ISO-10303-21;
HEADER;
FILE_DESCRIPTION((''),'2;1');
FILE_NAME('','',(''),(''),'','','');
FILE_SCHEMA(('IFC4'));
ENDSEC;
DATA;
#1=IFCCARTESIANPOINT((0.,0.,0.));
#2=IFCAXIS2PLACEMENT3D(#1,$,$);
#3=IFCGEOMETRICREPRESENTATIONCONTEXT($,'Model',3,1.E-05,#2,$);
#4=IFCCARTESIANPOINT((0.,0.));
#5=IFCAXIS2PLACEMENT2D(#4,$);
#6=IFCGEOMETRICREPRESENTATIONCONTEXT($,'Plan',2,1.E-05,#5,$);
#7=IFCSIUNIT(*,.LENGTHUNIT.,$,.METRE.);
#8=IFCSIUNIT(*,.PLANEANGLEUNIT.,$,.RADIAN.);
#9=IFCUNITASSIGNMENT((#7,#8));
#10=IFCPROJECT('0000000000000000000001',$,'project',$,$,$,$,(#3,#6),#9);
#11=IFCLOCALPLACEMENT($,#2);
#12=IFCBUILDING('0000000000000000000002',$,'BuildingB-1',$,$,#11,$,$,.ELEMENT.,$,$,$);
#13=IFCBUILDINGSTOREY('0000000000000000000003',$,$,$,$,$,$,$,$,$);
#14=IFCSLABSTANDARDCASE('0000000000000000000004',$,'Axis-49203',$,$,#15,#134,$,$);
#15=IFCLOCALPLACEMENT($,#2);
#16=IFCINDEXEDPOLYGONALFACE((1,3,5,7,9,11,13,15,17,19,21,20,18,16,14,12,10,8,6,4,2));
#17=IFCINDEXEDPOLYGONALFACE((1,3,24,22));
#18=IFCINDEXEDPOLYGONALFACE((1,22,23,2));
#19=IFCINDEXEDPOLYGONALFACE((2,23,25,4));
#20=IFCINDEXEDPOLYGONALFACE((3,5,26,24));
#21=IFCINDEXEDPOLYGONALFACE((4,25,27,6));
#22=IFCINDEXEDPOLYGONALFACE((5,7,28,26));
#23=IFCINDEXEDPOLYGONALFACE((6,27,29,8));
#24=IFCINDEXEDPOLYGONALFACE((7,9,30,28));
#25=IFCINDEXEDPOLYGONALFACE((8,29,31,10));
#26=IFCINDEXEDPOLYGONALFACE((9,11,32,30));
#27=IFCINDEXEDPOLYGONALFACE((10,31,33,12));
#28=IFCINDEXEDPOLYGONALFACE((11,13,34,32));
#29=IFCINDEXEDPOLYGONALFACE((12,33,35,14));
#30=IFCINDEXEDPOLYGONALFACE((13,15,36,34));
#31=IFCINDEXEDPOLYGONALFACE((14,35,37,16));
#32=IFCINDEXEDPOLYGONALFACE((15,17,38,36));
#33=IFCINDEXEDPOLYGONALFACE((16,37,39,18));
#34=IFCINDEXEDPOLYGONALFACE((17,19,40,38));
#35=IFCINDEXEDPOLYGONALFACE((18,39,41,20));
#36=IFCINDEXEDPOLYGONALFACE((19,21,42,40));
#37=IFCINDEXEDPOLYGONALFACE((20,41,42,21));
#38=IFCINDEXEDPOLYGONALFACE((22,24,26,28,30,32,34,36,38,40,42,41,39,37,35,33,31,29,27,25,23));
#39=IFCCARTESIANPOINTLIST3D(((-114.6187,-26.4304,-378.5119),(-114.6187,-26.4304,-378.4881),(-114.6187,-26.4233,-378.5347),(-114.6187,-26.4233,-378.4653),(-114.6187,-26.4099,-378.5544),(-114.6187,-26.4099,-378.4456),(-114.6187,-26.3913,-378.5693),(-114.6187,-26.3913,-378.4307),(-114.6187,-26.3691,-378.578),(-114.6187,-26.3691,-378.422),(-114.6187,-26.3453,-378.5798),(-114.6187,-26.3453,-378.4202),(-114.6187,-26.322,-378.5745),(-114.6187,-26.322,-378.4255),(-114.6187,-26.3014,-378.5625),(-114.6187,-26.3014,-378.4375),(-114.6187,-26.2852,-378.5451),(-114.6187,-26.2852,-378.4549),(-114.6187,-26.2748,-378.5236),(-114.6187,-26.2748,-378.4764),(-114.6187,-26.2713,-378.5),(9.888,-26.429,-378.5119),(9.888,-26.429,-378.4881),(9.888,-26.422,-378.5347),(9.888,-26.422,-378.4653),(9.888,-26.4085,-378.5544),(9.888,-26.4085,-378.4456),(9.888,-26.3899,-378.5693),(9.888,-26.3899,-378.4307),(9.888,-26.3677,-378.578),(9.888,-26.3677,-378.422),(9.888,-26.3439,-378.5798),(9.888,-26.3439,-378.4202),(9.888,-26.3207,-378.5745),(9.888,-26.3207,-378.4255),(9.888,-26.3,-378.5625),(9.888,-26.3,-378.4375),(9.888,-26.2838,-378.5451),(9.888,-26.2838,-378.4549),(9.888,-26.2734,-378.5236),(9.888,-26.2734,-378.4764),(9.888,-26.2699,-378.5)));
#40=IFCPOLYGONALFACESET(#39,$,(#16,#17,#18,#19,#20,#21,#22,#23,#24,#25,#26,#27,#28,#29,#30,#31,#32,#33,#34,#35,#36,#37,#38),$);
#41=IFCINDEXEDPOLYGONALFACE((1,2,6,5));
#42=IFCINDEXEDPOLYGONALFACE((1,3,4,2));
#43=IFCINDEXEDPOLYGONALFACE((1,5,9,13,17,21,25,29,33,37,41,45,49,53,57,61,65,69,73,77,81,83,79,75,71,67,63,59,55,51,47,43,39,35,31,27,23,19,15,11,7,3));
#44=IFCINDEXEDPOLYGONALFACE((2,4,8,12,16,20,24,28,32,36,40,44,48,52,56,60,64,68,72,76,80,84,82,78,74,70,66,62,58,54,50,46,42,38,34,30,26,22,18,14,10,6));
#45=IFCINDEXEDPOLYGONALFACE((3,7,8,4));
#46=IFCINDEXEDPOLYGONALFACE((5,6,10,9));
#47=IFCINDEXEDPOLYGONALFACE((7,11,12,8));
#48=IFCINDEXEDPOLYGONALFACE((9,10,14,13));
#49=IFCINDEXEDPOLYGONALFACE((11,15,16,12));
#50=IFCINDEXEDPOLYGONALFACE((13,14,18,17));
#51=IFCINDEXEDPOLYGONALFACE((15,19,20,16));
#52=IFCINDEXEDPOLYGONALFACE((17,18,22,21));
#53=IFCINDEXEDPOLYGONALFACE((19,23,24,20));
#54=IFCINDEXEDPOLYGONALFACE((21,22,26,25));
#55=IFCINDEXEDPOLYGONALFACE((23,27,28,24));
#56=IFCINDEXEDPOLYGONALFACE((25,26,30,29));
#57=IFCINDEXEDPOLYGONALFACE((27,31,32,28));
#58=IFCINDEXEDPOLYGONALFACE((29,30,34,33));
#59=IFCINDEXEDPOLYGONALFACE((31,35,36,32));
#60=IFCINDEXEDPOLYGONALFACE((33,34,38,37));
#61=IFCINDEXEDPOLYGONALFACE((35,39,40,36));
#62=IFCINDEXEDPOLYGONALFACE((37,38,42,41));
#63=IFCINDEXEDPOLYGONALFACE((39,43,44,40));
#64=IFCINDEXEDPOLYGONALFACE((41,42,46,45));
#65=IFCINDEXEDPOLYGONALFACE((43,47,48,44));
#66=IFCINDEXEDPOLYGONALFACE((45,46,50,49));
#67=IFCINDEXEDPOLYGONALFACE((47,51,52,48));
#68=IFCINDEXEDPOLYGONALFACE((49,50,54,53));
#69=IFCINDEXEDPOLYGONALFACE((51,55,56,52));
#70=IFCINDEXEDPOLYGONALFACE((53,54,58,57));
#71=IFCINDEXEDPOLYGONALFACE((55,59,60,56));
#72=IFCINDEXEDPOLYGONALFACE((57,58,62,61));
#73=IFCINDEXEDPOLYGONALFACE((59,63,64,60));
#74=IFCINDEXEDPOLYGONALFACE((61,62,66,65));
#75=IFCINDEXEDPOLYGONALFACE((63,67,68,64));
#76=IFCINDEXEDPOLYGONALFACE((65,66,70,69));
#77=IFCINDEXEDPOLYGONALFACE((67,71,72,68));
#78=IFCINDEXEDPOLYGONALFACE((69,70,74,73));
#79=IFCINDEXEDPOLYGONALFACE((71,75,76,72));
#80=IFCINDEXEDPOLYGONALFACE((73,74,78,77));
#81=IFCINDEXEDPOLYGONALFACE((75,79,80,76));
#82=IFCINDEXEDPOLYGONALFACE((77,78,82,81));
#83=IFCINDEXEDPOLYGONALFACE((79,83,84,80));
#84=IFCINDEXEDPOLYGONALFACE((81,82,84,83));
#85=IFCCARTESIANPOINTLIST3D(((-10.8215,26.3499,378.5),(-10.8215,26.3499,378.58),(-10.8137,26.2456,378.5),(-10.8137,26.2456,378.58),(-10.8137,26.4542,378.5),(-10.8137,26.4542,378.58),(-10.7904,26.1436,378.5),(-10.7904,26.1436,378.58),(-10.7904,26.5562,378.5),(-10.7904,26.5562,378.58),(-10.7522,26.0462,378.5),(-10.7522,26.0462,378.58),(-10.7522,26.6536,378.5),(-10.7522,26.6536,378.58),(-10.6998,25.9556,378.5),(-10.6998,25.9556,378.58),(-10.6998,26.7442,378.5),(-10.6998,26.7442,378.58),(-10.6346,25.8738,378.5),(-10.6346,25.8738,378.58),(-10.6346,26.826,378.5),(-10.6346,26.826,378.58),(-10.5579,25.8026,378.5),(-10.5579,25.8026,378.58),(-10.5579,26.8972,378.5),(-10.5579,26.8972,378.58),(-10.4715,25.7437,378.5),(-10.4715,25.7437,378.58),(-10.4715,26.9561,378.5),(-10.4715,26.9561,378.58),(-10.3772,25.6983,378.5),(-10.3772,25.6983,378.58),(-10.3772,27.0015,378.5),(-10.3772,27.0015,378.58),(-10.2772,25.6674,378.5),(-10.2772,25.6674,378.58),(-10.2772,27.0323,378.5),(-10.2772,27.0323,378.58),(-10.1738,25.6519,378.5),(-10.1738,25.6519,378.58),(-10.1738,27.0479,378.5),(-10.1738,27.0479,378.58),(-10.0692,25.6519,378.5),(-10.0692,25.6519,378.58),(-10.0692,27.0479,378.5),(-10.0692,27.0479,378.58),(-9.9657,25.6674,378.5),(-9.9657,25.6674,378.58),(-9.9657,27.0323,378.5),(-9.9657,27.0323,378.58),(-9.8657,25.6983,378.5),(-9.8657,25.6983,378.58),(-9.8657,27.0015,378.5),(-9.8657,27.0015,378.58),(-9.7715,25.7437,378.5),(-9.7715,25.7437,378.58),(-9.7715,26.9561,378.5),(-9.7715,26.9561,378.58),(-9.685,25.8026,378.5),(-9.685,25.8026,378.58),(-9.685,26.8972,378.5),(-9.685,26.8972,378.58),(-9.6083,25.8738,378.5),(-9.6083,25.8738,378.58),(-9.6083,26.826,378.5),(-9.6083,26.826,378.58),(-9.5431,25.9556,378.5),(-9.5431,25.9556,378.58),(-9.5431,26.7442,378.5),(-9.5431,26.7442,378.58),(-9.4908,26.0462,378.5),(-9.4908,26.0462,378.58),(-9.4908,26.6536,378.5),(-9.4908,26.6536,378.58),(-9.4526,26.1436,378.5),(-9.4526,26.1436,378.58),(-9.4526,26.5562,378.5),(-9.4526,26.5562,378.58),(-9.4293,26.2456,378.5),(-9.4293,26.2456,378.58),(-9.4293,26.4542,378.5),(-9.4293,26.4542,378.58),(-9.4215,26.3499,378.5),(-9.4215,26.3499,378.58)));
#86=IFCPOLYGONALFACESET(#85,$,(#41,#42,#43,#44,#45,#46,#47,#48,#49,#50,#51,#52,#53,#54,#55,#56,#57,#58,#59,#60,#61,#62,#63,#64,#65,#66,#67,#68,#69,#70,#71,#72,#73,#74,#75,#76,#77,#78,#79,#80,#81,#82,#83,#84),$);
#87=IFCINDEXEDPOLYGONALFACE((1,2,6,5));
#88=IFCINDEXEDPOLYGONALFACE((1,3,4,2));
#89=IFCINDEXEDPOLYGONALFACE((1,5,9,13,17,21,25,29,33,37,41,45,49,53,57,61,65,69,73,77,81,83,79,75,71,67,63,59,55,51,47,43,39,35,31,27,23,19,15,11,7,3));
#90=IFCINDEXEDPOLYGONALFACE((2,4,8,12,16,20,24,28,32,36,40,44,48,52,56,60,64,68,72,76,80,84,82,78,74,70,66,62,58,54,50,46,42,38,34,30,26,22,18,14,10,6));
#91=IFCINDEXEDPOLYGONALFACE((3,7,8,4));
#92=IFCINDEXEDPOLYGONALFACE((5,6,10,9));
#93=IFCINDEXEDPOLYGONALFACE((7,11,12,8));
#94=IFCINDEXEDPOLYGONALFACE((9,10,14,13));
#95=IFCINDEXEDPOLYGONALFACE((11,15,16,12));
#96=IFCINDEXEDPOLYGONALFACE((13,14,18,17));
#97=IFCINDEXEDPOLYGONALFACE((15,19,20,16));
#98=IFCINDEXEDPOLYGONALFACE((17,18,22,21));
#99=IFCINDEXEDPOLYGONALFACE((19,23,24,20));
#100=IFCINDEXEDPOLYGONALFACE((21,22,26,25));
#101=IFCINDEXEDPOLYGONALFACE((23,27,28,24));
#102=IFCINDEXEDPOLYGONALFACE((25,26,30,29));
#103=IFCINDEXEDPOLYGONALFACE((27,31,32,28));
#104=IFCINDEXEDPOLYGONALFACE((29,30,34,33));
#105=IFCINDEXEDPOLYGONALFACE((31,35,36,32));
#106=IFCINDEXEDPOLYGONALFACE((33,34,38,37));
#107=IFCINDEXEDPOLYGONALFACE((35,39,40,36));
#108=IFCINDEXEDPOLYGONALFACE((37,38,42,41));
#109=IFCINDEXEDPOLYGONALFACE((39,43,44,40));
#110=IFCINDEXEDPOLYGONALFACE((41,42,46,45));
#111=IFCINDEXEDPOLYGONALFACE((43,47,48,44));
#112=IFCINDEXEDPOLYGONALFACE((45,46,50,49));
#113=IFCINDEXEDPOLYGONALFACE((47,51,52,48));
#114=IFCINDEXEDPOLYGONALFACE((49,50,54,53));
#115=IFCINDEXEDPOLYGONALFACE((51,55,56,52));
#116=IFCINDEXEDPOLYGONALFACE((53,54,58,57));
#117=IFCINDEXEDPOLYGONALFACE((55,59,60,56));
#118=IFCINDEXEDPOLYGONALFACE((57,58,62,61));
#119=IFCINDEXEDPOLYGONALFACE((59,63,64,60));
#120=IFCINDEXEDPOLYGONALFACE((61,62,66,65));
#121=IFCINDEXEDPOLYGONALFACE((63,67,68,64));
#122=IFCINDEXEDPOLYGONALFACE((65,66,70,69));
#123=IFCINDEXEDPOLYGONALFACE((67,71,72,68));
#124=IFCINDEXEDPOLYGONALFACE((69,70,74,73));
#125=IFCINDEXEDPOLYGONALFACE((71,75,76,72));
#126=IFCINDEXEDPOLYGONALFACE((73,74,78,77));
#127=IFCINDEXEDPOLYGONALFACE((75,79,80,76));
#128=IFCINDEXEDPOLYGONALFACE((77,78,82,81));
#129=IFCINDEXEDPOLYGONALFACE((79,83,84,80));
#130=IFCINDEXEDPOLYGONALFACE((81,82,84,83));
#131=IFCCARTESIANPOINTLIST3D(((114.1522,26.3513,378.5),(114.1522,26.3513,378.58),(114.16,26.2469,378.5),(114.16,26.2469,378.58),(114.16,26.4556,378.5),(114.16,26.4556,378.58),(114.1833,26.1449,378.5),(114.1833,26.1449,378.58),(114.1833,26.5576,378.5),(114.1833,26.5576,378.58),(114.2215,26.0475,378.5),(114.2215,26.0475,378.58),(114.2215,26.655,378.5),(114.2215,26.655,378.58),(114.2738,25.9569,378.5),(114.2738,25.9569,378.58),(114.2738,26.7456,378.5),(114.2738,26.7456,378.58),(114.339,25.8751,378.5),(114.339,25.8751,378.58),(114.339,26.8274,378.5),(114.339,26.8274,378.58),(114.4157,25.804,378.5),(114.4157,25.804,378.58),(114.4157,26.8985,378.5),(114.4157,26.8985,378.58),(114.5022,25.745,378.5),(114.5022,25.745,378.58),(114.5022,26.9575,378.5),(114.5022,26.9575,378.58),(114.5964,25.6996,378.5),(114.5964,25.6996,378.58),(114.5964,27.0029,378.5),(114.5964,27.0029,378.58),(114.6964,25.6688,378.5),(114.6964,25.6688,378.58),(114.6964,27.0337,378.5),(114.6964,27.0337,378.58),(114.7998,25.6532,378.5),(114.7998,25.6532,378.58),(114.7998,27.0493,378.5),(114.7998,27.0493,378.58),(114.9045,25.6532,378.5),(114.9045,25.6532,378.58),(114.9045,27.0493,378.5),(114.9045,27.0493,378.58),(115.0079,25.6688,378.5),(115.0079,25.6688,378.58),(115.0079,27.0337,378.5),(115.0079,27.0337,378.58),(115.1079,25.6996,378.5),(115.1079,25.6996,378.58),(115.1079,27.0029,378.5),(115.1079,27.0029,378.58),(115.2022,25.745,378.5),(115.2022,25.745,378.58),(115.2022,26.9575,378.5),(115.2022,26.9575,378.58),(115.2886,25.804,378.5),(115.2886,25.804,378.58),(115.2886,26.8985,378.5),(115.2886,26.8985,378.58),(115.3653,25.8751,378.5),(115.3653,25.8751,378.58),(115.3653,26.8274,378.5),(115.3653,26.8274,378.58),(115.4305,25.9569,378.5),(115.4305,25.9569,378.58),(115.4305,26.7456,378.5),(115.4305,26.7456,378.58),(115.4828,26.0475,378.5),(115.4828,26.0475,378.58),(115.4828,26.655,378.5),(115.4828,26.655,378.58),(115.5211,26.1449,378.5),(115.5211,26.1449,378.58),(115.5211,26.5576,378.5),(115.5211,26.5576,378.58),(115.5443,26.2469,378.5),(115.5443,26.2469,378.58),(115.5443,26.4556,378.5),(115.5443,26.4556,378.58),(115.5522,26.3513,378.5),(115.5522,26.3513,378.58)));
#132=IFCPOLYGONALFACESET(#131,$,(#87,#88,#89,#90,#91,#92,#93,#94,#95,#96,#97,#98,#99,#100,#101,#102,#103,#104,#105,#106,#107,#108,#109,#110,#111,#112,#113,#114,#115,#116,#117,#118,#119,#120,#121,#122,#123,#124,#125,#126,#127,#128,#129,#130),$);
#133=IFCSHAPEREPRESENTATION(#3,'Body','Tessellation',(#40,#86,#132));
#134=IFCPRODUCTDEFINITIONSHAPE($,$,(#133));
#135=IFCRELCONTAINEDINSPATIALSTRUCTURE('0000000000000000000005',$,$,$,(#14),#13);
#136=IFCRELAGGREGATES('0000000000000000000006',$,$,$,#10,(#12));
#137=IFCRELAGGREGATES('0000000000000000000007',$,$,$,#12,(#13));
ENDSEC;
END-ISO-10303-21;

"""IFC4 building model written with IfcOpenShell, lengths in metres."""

from ifc_helpers import new_model, entity, si_unit, frame, origin, origin_2d, place, context, project, spatial, circle, extrude, element, save


model = new_model("IFC4")

# Units and contexts
model_context = context("Model", 3, precision=1e-05, world=origin())
plan_context = context("Plan", 2, precision=1e-05, world=origin_2d())
ifc_project = project(units=[si_unit("LENGTHUNIT", "METRE"), si_unit("PLANEANGLEUNIT", "RADIAN")], contexts=[model_context, plan_context])

# Building, storey
building_placement = place(None, origin())
building = spatial("IfcBuilding", under=ifc_project, at=building_placement, Name="BuildingB-1", CompositionType="ELEMENT")
storey = spatial("IfcBuildingStorey", under=building)

# Slab
element("IfcSlabStandardCase", 1, inside=storey, Name="Axis-49203", context=model_context, shape_type="AdvancedSweptSolid", body=[
    entity("IfcSurfaceCurveSweptAreaSolid", entity("IfcCircleProfileDef", "AREA", None, None, 0.08), None, entity("IfcPolyline", [entity("IfcCartesianPoint", [-9.888, 26.3499, 378.5]), entity("IfcCartesianPoint", [114.6187, 26.3513, 378.5])]), None, None, entity("IfcPlane", entity("IfcAxis2Placement3D", entity("IfcCartesianPoint", [-9.888, 26.3499, 378.5]), entity("IfcDirection", [0.0, 0.0, 1.0]), entity("IfcDirection", [1.0, 0.0, 0.0])))),
    extrude(circle(Radius=0.7), frame((-10.1215, 26.3499, 378.5)), (0.0, 0.0, 1.0), 0.08),
    extrude(circle(Radius=0.7), frame((114.8522, 26.3513, 378.5)), (0.0, 0.0, 1.0), 0.08),
])

save(model, "model.ifc")
